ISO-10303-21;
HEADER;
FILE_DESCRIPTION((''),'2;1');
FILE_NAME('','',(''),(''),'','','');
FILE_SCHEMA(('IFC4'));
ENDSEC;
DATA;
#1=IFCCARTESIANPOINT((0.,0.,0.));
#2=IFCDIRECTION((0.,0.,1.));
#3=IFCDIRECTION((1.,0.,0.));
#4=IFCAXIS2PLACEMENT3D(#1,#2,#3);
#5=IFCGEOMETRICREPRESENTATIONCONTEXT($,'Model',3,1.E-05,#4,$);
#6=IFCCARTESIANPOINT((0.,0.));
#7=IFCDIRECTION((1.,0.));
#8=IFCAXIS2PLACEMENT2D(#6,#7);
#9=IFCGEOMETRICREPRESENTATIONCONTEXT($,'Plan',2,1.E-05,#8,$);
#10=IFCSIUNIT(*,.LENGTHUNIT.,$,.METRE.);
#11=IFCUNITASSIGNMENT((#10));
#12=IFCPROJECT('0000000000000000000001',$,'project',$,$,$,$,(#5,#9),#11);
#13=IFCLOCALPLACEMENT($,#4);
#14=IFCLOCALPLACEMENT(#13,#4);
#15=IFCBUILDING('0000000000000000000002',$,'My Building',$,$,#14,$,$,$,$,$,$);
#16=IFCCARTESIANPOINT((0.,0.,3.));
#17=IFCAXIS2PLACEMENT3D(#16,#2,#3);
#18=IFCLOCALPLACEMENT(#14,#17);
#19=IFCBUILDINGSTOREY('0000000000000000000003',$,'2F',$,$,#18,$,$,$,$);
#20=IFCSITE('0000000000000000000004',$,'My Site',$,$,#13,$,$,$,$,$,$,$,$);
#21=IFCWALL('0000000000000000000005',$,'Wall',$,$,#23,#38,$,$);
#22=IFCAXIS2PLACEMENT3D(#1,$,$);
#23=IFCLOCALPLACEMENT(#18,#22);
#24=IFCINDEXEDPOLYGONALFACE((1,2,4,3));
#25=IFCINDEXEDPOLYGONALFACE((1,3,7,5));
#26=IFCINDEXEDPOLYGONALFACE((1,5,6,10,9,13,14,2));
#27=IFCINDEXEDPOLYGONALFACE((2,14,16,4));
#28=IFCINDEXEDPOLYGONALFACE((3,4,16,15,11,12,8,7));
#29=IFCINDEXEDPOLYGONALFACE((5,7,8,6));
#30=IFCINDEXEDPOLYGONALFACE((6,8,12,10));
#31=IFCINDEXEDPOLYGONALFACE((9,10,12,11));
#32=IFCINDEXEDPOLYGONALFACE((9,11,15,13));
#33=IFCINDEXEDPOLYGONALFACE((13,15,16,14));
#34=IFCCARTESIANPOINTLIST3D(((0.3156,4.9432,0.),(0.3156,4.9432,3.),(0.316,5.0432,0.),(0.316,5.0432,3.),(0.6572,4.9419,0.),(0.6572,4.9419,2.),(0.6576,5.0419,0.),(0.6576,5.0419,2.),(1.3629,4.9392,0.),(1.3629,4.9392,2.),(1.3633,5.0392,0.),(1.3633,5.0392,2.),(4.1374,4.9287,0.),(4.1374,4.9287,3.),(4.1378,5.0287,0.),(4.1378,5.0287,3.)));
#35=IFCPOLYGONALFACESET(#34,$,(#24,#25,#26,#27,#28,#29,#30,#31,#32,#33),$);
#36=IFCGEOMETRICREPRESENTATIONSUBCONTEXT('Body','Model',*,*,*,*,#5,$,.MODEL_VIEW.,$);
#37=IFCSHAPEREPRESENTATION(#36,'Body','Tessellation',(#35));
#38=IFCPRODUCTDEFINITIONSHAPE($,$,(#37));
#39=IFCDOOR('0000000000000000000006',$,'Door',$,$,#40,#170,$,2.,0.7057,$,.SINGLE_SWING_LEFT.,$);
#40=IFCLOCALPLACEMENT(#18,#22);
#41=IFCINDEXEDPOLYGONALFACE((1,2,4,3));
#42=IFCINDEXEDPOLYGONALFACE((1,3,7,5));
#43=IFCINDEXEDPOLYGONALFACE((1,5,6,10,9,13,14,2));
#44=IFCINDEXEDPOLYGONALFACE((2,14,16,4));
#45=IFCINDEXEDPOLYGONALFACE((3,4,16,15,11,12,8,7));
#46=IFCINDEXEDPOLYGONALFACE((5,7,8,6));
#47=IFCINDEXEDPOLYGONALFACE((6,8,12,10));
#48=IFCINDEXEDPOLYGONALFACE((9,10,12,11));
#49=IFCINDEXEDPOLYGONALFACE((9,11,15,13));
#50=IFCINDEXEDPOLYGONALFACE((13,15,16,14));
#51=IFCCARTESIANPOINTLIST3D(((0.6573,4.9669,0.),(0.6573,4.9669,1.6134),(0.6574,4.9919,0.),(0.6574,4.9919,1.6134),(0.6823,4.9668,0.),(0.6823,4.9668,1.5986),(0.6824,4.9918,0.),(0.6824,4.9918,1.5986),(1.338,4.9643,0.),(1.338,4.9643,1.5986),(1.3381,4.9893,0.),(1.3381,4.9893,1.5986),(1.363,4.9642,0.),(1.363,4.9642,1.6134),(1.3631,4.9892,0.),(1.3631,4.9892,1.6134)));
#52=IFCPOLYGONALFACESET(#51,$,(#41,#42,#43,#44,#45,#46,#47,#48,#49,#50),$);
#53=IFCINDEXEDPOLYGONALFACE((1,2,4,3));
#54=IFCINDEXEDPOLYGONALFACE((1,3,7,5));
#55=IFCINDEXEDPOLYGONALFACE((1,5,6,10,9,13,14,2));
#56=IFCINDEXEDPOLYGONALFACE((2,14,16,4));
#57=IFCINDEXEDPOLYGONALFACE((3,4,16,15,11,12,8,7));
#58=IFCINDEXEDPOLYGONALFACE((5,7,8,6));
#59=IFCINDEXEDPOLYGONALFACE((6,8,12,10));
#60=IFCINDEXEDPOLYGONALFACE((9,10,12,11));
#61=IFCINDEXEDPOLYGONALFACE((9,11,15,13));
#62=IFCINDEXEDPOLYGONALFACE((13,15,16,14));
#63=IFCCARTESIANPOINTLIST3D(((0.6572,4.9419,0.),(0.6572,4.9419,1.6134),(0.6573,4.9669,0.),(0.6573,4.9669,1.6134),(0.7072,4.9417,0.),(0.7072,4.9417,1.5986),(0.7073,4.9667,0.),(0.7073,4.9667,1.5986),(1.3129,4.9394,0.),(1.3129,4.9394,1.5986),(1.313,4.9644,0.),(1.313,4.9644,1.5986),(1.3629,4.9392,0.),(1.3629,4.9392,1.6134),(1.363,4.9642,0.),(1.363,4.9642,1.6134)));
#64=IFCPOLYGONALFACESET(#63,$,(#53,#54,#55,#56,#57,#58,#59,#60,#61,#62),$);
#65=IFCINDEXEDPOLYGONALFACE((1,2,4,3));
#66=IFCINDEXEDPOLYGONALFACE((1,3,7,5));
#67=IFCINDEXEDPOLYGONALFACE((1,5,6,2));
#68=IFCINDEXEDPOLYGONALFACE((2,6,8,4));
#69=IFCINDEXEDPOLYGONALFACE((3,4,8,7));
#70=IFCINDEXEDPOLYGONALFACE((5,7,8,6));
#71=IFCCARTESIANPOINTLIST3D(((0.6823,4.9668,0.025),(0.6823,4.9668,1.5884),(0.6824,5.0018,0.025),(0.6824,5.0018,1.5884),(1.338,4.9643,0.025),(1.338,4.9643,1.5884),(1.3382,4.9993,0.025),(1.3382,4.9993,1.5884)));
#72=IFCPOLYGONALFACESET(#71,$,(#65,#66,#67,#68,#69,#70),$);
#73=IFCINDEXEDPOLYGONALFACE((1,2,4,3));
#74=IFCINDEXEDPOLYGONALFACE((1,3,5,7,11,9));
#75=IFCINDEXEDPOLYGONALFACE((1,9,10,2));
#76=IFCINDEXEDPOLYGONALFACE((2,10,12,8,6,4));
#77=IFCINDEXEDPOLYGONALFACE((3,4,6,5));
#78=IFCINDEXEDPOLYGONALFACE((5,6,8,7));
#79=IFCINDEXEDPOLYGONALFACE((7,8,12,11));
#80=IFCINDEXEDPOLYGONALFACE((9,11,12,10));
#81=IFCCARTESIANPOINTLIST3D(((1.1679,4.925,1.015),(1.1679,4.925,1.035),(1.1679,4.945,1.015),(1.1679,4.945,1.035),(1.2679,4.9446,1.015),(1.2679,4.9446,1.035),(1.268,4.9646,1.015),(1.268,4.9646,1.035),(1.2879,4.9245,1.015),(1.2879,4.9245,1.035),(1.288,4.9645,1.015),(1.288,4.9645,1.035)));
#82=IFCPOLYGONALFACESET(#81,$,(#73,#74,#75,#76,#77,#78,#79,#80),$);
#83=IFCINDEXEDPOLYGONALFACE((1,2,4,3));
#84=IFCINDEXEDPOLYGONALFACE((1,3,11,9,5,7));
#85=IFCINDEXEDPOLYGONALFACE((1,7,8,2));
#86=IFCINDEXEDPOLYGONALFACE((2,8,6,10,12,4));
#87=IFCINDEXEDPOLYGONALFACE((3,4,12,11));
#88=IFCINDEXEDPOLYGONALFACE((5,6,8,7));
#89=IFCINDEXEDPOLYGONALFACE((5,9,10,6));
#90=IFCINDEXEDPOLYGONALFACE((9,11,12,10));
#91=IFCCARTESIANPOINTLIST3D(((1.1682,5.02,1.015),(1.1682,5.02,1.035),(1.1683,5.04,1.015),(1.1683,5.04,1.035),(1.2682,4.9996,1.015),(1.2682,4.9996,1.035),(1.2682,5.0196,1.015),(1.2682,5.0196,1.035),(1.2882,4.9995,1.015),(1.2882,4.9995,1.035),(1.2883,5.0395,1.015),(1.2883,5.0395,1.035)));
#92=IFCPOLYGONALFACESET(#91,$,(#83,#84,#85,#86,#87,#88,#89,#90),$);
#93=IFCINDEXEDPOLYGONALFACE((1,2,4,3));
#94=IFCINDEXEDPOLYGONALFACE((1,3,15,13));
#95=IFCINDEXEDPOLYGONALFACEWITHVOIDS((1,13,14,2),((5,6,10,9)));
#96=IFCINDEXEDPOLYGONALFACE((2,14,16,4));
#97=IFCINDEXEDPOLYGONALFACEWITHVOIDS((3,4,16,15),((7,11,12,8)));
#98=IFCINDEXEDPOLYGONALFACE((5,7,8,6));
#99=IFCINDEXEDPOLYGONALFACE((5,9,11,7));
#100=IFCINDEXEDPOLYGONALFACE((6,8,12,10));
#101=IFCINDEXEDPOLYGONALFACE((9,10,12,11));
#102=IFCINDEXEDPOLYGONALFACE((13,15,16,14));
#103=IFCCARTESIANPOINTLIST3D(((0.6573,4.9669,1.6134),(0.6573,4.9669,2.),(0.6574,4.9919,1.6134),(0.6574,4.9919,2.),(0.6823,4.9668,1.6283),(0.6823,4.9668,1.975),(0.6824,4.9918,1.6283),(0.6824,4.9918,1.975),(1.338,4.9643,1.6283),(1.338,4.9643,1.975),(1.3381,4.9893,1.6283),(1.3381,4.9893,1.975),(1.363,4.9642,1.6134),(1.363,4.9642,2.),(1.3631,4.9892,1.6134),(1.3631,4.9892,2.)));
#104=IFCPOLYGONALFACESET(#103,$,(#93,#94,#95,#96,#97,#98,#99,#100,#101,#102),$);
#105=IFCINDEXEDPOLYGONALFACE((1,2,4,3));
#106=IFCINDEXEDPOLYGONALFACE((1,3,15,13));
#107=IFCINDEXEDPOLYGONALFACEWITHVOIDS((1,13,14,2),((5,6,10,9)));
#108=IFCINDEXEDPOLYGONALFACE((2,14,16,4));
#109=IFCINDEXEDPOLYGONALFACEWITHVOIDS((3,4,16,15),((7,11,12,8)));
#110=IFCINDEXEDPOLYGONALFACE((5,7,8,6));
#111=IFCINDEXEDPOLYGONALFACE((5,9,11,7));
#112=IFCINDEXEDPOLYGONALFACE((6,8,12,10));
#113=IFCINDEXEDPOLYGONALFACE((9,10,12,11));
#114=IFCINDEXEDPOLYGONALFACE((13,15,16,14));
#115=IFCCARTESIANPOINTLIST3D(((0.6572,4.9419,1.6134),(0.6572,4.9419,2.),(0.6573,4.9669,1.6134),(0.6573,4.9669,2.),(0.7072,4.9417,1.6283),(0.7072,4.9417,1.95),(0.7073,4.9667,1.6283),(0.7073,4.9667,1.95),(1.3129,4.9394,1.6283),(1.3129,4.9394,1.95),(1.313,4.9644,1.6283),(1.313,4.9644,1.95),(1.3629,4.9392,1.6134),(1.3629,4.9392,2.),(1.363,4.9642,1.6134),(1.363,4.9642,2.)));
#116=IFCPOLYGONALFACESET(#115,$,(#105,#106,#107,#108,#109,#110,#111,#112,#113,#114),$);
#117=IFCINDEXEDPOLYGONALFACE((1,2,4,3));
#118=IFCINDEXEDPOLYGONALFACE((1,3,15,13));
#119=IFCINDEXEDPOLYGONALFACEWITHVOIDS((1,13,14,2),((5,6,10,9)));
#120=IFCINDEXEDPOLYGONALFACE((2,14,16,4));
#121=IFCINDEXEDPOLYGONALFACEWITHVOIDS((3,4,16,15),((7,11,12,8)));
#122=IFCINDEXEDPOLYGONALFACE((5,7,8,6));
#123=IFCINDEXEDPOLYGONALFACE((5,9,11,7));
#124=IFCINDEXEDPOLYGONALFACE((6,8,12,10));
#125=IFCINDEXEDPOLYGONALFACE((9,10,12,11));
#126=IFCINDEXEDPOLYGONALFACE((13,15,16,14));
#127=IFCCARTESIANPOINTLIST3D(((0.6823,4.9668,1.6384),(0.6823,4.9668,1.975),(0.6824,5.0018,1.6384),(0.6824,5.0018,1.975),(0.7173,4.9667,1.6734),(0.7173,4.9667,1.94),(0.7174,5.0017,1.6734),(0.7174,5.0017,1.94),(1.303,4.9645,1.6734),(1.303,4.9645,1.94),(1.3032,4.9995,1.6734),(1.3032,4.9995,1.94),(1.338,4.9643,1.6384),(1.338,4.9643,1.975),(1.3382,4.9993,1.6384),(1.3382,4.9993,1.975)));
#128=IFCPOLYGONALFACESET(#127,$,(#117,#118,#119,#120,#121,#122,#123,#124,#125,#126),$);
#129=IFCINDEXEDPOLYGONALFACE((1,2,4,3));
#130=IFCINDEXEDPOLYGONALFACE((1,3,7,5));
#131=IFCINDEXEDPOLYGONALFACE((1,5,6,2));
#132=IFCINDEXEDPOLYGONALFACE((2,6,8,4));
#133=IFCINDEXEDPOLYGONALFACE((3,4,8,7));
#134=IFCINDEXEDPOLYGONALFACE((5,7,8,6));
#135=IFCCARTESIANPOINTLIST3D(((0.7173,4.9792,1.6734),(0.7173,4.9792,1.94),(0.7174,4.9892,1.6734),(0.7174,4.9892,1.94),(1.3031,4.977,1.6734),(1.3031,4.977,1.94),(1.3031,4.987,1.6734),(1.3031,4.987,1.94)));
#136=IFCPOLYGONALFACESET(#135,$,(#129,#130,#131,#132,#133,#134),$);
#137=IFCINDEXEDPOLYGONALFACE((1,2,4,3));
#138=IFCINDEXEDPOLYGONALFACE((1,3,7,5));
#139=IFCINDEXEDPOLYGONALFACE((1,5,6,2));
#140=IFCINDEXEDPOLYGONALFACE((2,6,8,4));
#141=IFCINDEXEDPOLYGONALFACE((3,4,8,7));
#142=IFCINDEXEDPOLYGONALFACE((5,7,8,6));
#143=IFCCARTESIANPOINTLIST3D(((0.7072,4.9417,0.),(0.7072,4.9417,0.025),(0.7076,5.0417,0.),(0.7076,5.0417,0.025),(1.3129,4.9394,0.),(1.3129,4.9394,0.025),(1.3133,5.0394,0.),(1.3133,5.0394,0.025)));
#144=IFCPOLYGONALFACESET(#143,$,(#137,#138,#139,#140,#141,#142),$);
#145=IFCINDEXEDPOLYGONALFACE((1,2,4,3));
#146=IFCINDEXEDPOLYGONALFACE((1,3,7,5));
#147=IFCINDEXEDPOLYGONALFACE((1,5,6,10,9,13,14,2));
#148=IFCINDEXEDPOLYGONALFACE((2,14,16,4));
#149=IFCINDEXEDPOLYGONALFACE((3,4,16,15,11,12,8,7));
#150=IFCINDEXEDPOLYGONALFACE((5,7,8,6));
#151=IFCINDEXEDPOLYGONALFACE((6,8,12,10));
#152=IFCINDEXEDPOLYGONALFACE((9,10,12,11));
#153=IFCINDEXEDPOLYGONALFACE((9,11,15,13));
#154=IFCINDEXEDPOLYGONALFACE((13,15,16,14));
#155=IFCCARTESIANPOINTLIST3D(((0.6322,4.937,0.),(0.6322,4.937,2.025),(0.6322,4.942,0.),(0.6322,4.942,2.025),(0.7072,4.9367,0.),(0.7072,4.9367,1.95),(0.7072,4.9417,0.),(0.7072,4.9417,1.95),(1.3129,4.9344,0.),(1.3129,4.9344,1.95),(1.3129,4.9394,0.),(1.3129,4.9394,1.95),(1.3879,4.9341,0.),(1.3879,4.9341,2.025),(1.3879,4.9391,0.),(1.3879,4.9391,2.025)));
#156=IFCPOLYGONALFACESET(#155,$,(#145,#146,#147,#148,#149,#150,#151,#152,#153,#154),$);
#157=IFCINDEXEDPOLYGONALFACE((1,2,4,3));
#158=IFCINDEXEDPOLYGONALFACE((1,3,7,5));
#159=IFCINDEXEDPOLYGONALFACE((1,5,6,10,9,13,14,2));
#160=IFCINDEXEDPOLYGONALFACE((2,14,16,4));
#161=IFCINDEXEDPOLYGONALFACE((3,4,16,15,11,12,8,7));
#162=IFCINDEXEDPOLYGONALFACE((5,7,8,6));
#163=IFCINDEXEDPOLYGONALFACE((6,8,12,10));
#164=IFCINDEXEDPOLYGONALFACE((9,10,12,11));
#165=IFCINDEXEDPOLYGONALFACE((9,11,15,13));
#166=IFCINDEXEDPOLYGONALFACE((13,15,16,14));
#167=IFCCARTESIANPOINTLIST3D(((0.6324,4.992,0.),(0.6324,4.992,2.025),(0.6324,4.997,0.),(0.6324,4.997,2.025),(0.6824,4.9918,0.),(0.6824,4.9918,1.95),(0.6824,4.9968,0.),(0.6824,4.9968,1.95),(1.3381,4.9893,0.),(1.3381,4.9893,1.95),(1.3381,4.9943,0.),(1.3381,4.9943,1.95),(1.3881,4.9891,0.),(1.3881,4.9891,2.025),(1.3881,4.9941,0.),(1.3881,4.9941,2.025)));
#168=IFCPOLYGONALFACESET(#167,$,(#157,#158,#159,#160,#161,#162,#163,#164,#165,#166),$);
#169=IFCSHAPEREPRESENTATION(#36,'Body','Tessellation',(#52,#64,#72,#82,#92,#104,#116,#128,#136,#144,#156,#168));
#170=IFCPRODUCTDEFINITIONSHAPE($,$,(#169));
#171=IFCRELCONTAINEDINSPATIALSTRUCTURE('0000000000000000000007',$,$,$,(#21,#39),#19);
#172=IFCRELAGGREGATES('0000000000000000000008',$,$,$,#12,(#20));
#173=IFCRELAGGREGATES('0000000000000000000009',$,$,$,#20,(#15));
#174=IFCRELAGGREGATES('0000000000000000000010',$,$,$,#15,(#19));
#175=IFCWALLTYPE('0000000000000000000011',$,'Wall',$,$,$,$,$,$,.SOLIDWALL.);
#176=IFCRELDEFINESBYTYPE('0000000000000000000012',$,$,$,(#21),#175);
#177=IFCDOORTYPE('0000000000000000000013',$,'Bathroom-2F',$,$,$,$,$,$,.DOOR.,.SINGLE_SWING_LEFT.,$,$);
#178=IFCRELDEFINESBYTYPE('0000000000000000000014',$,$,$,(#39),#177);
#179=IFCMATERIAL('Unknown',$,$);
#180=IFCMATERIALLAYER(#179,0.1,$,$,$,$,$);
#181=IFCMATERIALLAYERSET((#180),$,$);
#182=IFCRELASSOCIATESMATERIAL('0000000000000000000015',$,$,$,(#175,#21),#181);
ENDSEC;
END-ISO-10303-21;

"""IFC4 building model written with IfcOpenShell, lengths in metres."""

from ifc_helpers import new_model, entity, si_unit, frame, origin_with_axes, origin_2d_with_axis, place, context, subcontext, project, spatial, line, indexed_curve, outline, extrude, shape, source, transform, mapped, material, layer, layer_set, layer_usage, type_object, type_shapes, element, fill, save


model = new_model("IFC4")

# Units and contexts
model_context = context("Model", 3, precision=1e-05, world=origin_with_axes())
plan_context = context("Plan", 2, precision=1e-05, world=origin_2d_with_axis())
body_context_1 = subcontext(model_context, "Body", "Model", "MODEL_VIEW")
body_context_2 = subcontext(plan_context, "Body", "Plan", "PLAN_VIEW")
ifc_project = project(units=[si_unit("LENGTHUNIT", "METRE")], contexts=[model_context, plan_context])

# Site, building, storey
site_placement = place(None, origin_with_axes())
site = spatial("IfcSite", under=ifc_project, at=site_placement, Name="My Site")
building_placement = place(site_placement, origin_with_axes())
building = spatial("IfcBuilding", under=site, at=building_placement, Name="My Building")
storey_placement = place(building_placement, frame((0.0, 0.0, 3.0), z_axis=(0.0, 0.0, 1.0), x_axis=(1.0, 0.0, 0.0)))
storey = spatial("IfcBuildingStorey", under=building, at=storey_placement, Name="2F")

# Shared definitions
ifc_material = material(Name="Unknown")

# Shared definitions
ifc_layer = layer(ifc_material, 0.1)
ifc_layer_set = layer_set([ifc_layer])
wall_type = type_object("IfcWallType", Name="Wall", PredefinedType="SOLIDWALL", material=ifc_layer_set)

# Wall, opening, door
ifc_layer_usage_1 = layer_usage(ifc_layer_set, "AXIS2", "POSITIVE", 0.0)
wall_1_placement = place(storey_placement, frame((4.1378, 5.0287, 0.0), z_axis=(0.0, 0.0, 1.0), x_axis=(-0.999993, 0.003807, 0.0)))
wall_1 = element("IfcWall", 1, at=wall_1_placement, inside=storey, type_object=wall_type, material=ifc_layer_usage_1, Name="Wall", context=body_context_1, shape_type="SweptSolid", body=[
    extrude(outline(indexed_curve([(0.0, 0.0), (0.0, 0.1), (3.8218, 0.1), (3.8218, 0.0)], segments=[line(1, 2, 3, 4, 1)])), origin_with_axes(), (0.0, 0.0, 1.0), 3.0),
])
shared_shape_1 = source(origin_with_axes(), body_context_1, "Body", "SweptSolid", [
    extrude(outline(indexed_curve([(0.0, 0.0), (0.7057, 0.0), (0.7057, 2.0), (0.0, 2.0)], segments=[line(1, 2, 3, 4, 1)])), frame((0.0, -0.6, 0.0), z_axis=(0.0, -1.0, 0.0), x_axis=(1.0, 0.0, 0.0)), (0.0, 0.0, -1.0), 1.2),
])
opening_1_placement = place(wall_1_placement, frame((3.4802, 0.1, 0.0), z_axis=(0.0, 0.0, 1.0), x_axis=(-1.0, 0.000001, 0.0)))
opening_1 = element("IfcOpeningElement", 2, at=opening_1_placement, cuts=wall_1, PredefinedType="OPENING", context=body_context_1, shape_type="MappedRepresentation", body=[
    mapped(shared_shape_1, transform((0.0, 0.0, 0.0), x_axis=(1.0, 0.0, 0.0), y_axis=(0.0, 1.0, 0.0), z_axis=(0.0, 0.0, 1.0), scale=1.0)),
])
door_type = type_object("IfcDoorType", Name="Bathroom-2F", OperationType="SINGLE_SWING_LEFT", PredefinedType="DOOR")
shared_shape_2 = source(origin_with_axes(), body_context_1, "Body", "SweptSolid", [
    extrude(outline(indexed_curve([(0.0, 0.0), (0.0, 1.6134), (0.7057, 1.6134), (0.7057, 0.0), (0.6807, 0.0), (0.6807, 1.5986), (0.025, 1.5986), (0.025, 0.0)], segments=[line(1, 2, 3, 4, 5, 6, 7, 8, 1)])), frame((0.0, 0.025, 0.0), z_axis=(0.0, -1.0, 0.0), x_axis=(1.0, 0.0, 0.0)), (0.0, 0.0, -1.0), 0.025),
    extrude(outline(indexed_curve([(0.0, 0.0), (0.0, 1.6134), (0.7057, 1.6134), (0.7057, 0.0), (0.6557, 0.0), (0.6557, 1.5986), (0.05, 1.5986), (0.05, 0.0)], segments=[line(1, 2, 3, 4, 5, 6, 7, 8, 1)])), frame((0.0, 0.0, 0.0), z_axis=(0.0, -1.0, 0.0), x_axis=(1.0, 0.0, 0.0)), (0.0, 0.0, -1.0), 0.025),
    extrude(outline(indexed_curve([(0.0, 0.0), (0.6557, 0.0), (0.6557, 0.035), (0.0, 0.035)], segments=[line(1, 2, 3, 4, 1)])), frame((0.025, 0.025, 0.025), z_axis=(0.0, 0.0, 1.0), x_axis=(1.0, 0.0, 0.0)), (0.0, 0.0, 1.0), 1.5634),
    extrude(outline(indexed_curve([(0.0, 0.0), (0.0, -0.04), (-0.12, -0.04), (-0.12, -0.02), (-0.02, -0.02), (-0.02, 0.0)], segments=[line(1, 2, 3, 4, 5, 6, 1)])), frame((0.6307, 0.025, 1.015), z_axis=(0.0, 0.0, 1.0), x_axis=(1.0, 0.0, 0.0)), (0.0, 0.0, 1.0), 0.02),
    extrude(outline(indexed_curve([(0.0, 0.0), (0.0, 0.04), (-0.12, 0.04), (-0.12, 0.02), (-0.02, 0.02), (-0.02, 0.0)], segments=[line(1, 2, 3, 4, 5, 6, 1)])), frame((0.6307, 0.06, 1.015), z_axis=(0.0, 0.0, 1.0), x_axis=(1.0, 0.0, 0.0)), (0.0, 0.0, 1.0), 0.02),
    extrude(outline(indexed_curve([(0.0, 0.0), (0.7057, 0.0), (0.7057, 0.3866), (0.0, 0.3866)], segments=[line(1, 2, 3, 4, 1)]), holes=[indexed_curve([(0.025, 0.0148), (0.6807, 0.0148), (0.6807, 0.3616), (0.025, 0.3616)], segments=[line(1, 2, 3, 4, 1)])]), frame((0.0, 0.025, 1.6134), z_axis=(0.0, -1.0, 0.0), x_axis=(1.0, 0.0, 0.0)), (0.0, 0.0, -1.0), 0.025),
    extrude(outline(indexed_curve([(0.0, 0.0), (0.7057, 0.0), (0.7057, 0.3866), (0.0, 0.3866)], segments=[line(1, 2, 3, 4, 1)]), holes=[indexed_curve([(0.05, 0.0148), (0.6557, 0.0148), (0.6557, 0.3366), (0.05, 0.3366)], segments=[line(1, 2, 3, 4, 1)])]), frame((0.0, 0.0, 1.6134), z_axis=(0.0, -1.0, 0.0), x_axis=(1.0, 0.0, 0.0)), (0.0, 0.0, -1.0), 0.025),
    extrude(outline(indexed_curve([(0.0, 0.0), (0.6557, 0.0), (0.6557, 0.3366), (0.0, 0.3366)], segments=[line(1, 2, 3, 4, 1)]), holes=[indexed_curve([(0.035, 0.035), (0.6207, 0.035), (0.6207, 0.3016), (0.035, 0.3016)], segments=[line(1, 2, 3, 4, 1)])]), frame((0.025, 0.025, 1.6384), z_axis=(0.0, -1.0, 0.0), x_axis=(1.0, 0.0, 0.0)), (0.0, 0.0, -1.0), 0.035),
    extrude(outline(indexed_curve([(0.035, 0.035), (0.6207, 0.035), (0.6207, 0.3016), (0.035, 0.3016)], segments=[line(1, 2, 3, 4, 1)])), frame((0.025, 0.0375, 1.6384), z_axis=(0.0, -1.0, 0.0), x_axis=(1.0, 0.0, 0.0)), (0.0, 0.0, -1.0), 0.01),
    extrude(outline(indexed_curve([(0.0, 0.0), (0.6057, 0.0), (0.6057, 0.1), (0.0, 0.1)], segments=[line(1, 2, 3, 4, 1)])), frame((0.05, 0.0, 0.0), z_axis=(0.0, 0.0, 1.0), x_axis=(1.0, 0.0, 0.0)), (0.0, 0.0, 1.0), 0.025),
    extrude(outline(indexed_curve([(0.0, 0.0), (0.0, 2.025), (0.7557, 2.025), (0.7557, 0.0), (0.6807, 0.0), (0.6807, 1.95), (0.075, 1.95), (0.075, 0.0)], segments=[line(1, 2, 3, 4, 5, 6, 7, 8, 1)])), frame((-0.025, -0.005, 0.0), z_axis=(0.0, -1.0, 0.0), x_axis=(1.0, 0.0, 0.0)), (0.0, 0.0, -1.0), 0.005),
    extrude(outline(indexed_curve([(0.0, 0.0), (0.0, 2.025), (0.7557, 2.025), (0.7557, 0.0), (0.7057, 0.0), (0.7057, 1.95), (0.05, 1.95), (0.05, 0.0)], segments=[line(1, 2, 3, 4, 5, 6, 7, 8, 1)])), frame((-0.025, 0.05, 0.0), z_axis=(0.0, -1.0, 0.0), x_axis=(1.0, 0.0, 0.0)), (0.0, 0.0, -1.0), 0.005),
])
shared_shape_3 = source(origin_with_axes(), body_context_2, "Body", "Curve2D", [
    entity("IfcIndexedPolyCurve", entity("IfcCartesianPointList2D", [[0.0, 0.0], [0.0, 0.05], [0.025, 0.05], [0.025, 0.025], [0.05, 0.025], [0.05, 0.0]]), [entity("IfcLineIndex", [1, 2, 3, 4, 5, 6, 1])]),
    entity("IfcIndexedPolyCurve", entity("IfcCartesianPointList2D", [[0.7057, 0.0], [0.7057, 0.05], [0.6807, 0.05], [0.6807, 0.025], [0.6557, 0.025], [0.6557, 0.0]]), [entity("IfcLineIndex", [1, 2, 3, 4, 5, 6, 1])]),
    entity("IfcTrimmedCurve", entity("IfcEllipse", entity("IfcAxis2Placement2D", entity("IfcCartesianPoint", [0.06, 0.05]), entity("IfcDirection", [1.0, 0.0])), 0.6207, 0.6557), [entity("IfcCartesianPoint", [0.6807, 0.05])], [entity("IfcCartesianPoint", [0.06, 0.7057])], True, "CARTESIAN"),
    entity("IfcIndexedPolyCurve", entity("IfcCartesianPointList2D", [[0.025, 0.05], [0.06, 0.05], [0.06, 0.7057], [0.025, 0.7057]]), [entity("IfcLineIndex", [1, 2, 3, 4, 1])]),
])
type_shapes(door_type, [shared_shape_2, shared_shape_3])
door_placement = place(opening_1_placement, frame((0.0, 0.0, 0.0), z_axis=(0.0, 0.0, 1.0), x_axis=(1.0, 0.0, 0.0)))
door = element("IfcDoor", 3, at=door_placement, inside=storey, type_object=door_type, Name="Door", OperationType="SINGLE_SWING_LEFT", OverallHeight=2.0, OverallWidth=0.7057, shapes=[
    shape(body_context_1, "Body", "MappedRepresentation", [mapped(shared_shape_2, transform((0.0, 0.0, 0.0), x_axis=(1.0, 0.0, 0.0), y_axis=(0.0, 1.0, 0.0), z_axis=(0.0, 0.0, 1.0), scale=1.0))]),
    shape(body_context_2, "Body", "MappedRepresentation", [mapped(shared_shape_3, transform((0.0, 0.0, 0.0), x_axis=(1.0, 0.0, 0.0), y_axis=(0.0, 1.0, 0.0), z_axis=(0.0, 0.0, 1.0), scale=1.0))]),
])
fill(opening_1, door)

save(model, "model.ifc")
